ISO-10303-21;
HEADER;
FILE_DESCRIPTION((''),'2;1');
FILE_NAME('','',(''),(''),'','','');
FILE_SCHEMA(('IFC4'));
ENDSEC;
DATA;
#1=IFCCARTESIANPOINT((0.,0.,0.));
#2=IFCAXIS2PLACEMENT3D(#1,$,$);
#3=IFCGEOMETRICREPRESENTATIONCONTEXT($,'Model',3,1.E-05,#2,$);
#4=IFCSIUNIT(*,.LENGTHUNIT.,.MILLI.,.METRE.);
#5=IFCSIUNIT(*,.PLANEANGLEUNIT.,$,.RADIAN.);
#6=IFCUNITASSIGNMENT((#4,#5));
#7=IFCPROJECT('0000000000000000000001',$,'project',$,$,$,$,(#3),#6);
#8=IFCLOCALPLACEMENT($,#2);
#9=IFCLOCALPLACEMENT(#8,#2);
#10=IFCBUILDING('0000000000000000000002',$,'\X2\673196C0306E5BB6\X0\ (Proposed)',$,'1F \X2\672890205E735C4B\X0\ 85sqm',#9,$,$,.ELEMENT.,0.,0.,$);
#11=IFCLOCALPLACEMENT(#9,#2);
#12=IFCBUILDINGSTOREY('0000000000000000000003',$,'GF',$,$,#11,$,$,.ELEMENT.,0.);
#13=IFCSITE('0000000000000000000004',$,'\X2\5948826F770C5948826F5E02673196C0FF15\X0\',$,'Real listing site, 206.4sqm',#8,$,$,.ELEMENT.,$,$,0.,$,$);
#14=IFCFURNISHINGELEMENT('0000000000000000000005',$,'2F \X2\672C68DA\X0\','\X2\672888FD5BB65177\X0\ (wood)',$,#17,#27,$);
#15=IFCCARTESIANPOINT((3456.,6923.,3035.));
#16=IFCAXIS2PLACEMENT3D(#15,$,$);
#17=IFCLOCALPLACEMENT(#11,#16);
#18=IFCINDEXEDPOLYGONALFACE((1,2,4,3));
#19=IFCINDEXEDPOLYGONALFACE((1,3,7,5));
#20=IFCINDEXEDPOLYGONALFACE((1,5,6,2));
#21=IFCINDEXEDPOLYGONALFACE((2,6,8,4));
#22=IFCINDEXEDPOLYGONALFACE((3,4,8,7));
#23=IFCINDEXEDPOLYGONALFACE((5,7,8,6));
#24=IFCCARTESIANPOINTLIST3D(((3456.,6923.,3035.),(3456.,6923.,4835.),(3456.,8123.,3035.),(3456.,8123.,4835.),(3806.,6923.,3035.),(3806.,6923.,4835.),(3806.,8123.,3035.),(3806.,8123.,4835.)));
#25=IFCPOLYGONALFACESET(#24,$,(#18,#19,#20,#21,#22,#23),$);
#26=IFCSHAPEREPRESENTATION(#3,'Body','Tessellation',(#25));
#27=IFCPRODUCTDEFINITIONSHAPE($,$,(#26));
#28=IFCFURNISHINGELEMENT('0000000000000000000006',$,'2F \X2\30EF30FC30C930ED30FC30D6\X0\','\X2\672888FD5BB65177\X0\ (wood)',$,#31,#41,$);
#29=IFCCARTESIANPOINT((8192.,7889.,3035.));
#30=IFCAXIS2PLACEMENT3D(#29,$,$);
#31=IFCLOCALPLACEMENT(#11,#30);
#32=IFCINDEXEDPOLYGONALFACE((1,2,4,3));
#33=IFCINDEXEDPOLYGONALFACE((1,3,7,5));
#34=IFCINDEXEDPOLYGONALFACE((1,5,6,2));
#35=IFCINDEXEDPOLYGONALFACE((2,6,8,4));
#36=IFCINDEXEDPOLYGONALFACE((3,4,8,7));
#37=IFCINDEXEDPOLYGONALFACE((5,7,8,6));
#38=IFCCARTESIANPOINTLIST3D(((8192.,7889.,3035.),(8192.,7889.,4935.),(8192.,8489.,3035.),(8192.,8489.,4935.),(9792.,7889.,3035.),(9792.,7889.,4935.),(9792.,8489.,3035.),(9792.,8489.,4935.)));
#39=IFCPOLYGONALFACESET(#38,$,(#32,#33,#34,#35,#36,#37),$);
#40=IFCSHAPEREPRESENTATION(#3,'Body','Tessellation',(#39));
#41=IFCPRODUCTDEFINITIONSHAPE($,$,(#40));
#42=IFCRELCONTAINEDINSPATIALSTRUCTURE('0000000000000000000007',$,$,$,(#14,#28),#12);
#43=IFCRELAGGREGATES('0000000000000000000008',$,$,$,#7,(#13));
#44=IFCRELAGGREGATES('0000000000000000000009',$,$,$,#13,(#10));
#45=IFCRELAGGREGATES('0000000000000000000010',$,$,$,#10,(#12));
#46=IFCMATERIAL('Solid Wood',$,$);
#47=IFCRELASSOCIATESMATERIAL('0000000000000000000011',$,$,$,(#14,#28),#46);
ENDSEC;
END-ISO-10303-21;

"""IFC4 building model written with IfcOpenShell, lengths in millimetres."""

from ifc_helpers import new_model, si_unit, frame, frame_2d, origin, place, context, project, spatial, rectangle, extrude, material, element, save


model = new_model("IFC4")

# Units and contexts
model_context = context("Model", 3, precision=1e-05, world=origin())
ifc_project = project(units=[si_unit("LENGTHUNIT", "METRE", prefix="MILLI"), si_unit("PLANEANGLEUNIT", "RADIAN")], contexts=[model_context])

# Site, building, storey
site_placement = place(None, origin())
site = spatial("IfcSite", under=ifc_project, at=site_placement, Name="奈良県奈良市朱雀５", ObjectType="Real listing site, 206.4sqm", CompositionType="ELEMENT", RefElevation=0.0)
building_placement = place(site_placement, origin())
building = spatial("IfcBuilding", under=site, at=building_placement, Name="朱雀の家 (Proposed)", ObjectType="1F 木造平屋 85sqm", CompositionType="ELEMENT", ElevationOfRefHeight=0.0, ElevationOfTerrain=0.0)
storey_placement = place(building_placement, origin())
storey = spatial("IfcBuildingStorey", under=building, at=storey_placement, Name="GF", CompositionType="ELEMENT", Elevation=0.0)

# Shared definitions
ifc_material_1 = material(Name="Solid Wood")

# Furnishing elements
furnishing_1_placement = place(storey_placement, frame((3456.0, 6923.0, 3035.0)))
element("IfcFurnishingElement", 1, at=furnishing_1_placement, inside=storey, material=ifc_material_1, Name="2F 本棚", Description="木製家具 (wood)", context=model_context, shape_type="SweptSolid", body=[
    extrude(rectangle(XDim=350.0, YDim=1200.0, at=frame_2d((175.0, 600.0))), frame((3456.0, 6923.0, 3035.0)), (0.0, 0.0, 1.0), 1800.0),
])
furnishing_2_placement = place(storey_placement, frame((8192.0, 7889.0, 3035.0)))
element("IfcFurnishingElement", 2, at=furnishing_2_placement, inside=storey, material=ifc_material_1, Name="2F ワードローブ", Description="木製家具 (wood)", context=model_context, shape_type="SweptSolid", body=[
    extrude(rectangle(XDim=1600.0, YDim=600.0, at=frame_2d((800.0, 300.0))), frame((8192.0, 7889.0, 3035.0)), (0.0, 0.0, 1.0), 1900.0),
])

save(model, "model.ifc")
